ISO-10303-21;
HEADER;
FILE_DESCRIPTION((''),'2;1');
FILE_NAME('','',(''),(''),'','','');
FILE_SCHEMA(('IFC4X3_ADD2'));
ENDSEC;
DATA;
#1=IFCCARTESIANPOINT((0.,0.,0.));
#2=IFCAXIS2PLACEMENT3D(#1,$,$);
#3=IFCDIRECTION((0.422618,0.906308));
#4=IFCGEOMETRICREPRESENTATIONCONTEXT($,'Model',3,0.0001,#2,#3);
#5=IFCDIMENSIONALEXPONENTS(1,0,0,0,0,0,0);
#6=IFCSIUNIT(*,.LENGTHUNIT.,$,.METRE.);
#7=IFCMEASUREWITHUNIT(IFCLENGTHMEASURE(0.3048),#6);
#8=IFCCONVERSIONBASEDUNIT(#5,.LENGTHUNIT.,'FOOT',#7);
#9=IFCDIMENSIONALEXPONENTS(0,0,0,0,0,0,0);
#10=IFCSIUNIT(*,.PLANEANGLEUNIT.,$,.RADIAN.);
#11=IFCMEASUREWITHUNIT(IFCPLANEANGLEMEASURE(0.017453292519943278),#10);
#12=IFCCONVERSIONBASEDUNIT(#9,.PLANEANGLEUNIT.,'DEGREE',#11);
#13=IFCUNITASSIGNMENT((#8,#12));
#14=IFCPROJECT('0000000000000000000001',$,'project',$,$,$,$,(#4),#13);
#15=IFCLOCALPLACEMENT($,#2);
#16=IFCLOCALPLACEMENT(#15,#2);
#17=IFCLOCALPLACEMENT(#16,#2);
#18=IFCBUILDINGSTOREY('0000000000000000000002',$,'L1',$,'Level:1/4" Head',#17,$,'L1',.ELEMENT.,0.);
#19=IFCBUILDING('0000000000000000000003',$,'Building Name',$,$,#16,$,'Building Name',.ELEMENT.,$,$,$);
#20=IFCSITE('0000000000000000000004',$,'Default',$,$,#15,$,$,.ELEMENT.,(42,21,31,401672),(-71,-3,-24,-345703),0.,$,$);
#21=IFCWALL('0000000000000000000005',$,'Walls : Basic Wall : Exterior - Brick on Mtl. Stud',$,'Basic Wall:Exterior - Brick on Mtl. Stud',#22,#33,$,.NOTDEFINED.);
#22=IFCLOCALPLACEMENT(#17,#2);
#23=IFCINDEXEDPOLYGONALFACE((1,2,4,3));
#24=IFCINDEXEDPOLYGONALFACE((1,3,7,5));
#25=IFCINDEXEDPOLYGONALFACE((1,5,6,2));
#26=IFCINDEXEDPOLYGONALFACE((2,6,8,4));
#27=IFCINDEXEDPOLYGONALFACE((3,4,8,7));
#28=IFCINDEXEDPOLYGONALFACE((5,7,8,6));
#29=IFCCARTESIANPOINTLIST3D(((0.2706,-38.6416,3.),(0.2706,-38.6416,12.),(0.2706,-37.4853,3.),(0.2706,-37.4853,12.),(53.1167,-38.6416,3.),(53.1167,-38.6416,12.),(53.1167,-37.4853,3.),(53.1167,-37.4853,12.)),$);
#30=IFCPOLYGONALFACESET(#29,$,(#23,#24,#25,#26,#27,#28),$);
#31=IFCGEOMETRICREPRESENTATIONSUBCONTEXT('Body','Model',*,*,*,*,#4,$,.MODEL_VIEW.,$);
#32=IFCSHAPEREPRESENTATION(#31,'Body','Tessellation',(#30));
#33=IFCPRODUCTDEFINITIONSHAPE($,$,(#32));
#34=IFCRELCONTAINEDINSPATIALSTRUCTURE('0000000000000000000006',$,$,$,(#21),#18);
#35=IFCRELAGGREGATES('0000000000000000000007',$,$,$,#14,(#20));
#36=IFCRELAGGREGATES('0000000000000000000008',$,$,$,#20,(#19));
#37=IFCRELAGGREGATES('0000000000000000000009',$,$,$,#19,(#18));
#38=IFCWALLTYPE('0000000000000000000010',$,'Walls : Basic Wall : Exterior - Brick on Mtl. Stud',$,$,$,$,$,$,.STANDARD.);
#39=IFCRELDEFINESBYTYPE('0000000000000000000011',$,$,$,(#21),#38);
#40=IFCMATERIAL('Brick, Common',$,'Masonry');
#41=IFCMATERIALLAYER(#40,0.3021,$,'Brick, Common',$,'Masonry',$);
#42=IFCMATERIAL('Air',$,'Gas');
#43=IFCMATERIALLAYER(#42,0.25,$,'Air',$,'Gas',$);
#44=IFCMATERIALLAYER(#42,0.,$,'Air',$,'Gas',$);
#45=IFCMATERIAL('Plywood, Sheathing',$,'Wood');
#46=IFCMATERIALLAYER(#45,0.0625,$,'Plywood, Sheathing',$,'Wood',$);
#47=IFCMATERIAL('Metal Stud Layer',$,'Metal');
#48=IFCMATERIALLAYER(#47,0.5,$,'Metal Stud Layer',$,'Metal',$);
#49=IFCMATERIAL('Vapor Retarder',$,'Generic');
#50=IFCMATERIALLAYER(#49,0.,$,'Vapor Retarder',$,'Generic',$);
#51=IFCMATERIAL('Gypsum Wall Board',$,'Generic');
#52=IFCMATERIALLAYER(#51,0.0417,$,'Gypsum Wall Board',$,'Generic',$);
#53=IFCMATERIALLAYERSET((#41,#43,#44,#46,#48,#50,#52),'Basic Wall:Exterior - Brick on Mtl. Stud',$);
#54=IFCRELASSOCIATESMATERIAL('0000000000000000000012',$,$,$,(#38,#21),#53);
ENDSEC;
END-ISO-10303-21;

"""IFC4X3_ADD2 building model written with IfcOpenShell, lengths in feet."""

from ifc_helpers import new_model, entity, si_unit, converted_unit, direction, frame, frame_2d, origin, place, context, subcontext, project, spatial, rectangle, extrude, material, layer, layer_set, type_object, element, save


model = new_model("IFC4X3_ADD2")

# Units and contexts
model_context = context("Model", 3, precision=0.0001, world=origin(), true_north=direction((0.422618, 0.906308)))
body_context = subcontext(model_context, "Body", "Model", "MODEL_VIEW")
ifc_project = project(units=[converted_unit("LENGTHUNIT", "FOOT", entity("IfcLengthMeasure", 0.3048), si_unit("LENGTHUNIT", "METRE"), dimensions=[1, 0, 0, 0, 0, 0, 0]), converted_unit("PLANEANGLEUNIT", "DEGREE", entity("IfcPlaneAngleMeasure", 0.017453292519943278), si_unit("PLANEANGLEUNIT", "RADIAN"), dimensions=[0, 0, 0, 0, 0, 0, 0])], contexts=[model_context])

# Site, building, storey
site_placement = place(None, origin())
site = spatial("IfcSite", under=ifc_project, at=site_placement, Name="Default", CompositionType="ELEMENT", RefLatitude=(42, 21, 31, 401672), RefLongitude=(-71, -3, -24, -345703), RefElevation=0.0)
building_placement = place(site_placement, origin())
building = spatial("IfcBuilding", under=site, at=building_placement, Name="Building Name", LongName="Building Name", CompositionType="ELEMENT")
storey_placement = place(building_placement, origin())
storey = spatial("IfcBuildingStorey", under=building, at=storey_placement, Name="L1", ObjectType="Level:1/4\" Head", LongName="L1", CompositionType="ELEMENT", Elevation=0.0)

# Shared definitions
ifc_material_1 = material(Name="Plywood, Sheathing", Category="Wood")

# Wall
ifc_material_2 = material(Name="Air", Category="Gas")
ifc_material_3 = material(Name="Metal Stud Layer", Category="Metal")
ifc_material_4 = material(Name="Vapor Retarder", Category="Generic")
ifc_material_5 = material(Name="Gypsum Wall Board", Category="Generic")
ifc_material_6 = material(Name="Brick, Common", Category="Masonry")
ifc_layer_1 = layer(ifc_material_6, 0.3021, Name="Brick, Common", Category="Masonry")
ifc_layer_2 = layer(ifc_material_2, 0.25, Name="Air", Category="Gas")
ifc_layer_3 = layer(ifc_material_2, 0.0, Name="Air", Category="Gas")
ifc_layer_4 = layer(ifc_material_1, 0.0625, Name="Plywood, Sheathing", Category="Wood")
ifc_layer_5 = layer(ifc_material_3, 0.5, Name="Metal Stud Layer", Category="Metal")
ifc_layer_6 = layer(ifc_material_4, 0.0, Name="Vapor Retarder", Category="Generic")
ifc_layer_7 = layer(ifc_material_5, 0.0417, Name="Gypsum Wall Board", Category="Generic")
ifc_layer_set_1 = layer_set([ifc_layer_1, ifc_layer_2, ifc_layer_3, ifc_layer_4, ifc_layer_5, ifc_layer_6, ifc_layer_7], Name="Basic Wall:Exterior - Brick on Mtl. Stud")
wall_type_1 = type_object("IfcWallType", Name="Walls : Basic Wall : Exterior - Brick on Mtl. Stud", PredefinedType="STANDARD", material=ifc_layer_set_1)
wall_1_placement = place(storey_placement, frame((53.1167, -38.0635, 3.0), z_axis=(0.0, 0.0, 1.0), x_axis=(-1.0, 0.0, 0.0)))
element("IfcWall", 1, at=wall_1_placement, inside=storey, type_object=wall_type_1, material=ifc_layer_set_1, Name="Walls : Basic Wall : Exterior - Brick on Mtl. Stud", ObjectType="Basic Wall:Exterior - Brick on Mtl. Stud", PredefinedType="NOTDEFINED", context=body_context, shape_type="SweptSolid", body=[
    extrude(rectangle(XDim=52.8461, YDim=1.1562, at=frame_2d((26.423, 0.0), x_axis=(-1.0, 0.0))), origin(), (0.0, 0.0, 1.0), 9.0),
])

save(model, "model.ifc")
